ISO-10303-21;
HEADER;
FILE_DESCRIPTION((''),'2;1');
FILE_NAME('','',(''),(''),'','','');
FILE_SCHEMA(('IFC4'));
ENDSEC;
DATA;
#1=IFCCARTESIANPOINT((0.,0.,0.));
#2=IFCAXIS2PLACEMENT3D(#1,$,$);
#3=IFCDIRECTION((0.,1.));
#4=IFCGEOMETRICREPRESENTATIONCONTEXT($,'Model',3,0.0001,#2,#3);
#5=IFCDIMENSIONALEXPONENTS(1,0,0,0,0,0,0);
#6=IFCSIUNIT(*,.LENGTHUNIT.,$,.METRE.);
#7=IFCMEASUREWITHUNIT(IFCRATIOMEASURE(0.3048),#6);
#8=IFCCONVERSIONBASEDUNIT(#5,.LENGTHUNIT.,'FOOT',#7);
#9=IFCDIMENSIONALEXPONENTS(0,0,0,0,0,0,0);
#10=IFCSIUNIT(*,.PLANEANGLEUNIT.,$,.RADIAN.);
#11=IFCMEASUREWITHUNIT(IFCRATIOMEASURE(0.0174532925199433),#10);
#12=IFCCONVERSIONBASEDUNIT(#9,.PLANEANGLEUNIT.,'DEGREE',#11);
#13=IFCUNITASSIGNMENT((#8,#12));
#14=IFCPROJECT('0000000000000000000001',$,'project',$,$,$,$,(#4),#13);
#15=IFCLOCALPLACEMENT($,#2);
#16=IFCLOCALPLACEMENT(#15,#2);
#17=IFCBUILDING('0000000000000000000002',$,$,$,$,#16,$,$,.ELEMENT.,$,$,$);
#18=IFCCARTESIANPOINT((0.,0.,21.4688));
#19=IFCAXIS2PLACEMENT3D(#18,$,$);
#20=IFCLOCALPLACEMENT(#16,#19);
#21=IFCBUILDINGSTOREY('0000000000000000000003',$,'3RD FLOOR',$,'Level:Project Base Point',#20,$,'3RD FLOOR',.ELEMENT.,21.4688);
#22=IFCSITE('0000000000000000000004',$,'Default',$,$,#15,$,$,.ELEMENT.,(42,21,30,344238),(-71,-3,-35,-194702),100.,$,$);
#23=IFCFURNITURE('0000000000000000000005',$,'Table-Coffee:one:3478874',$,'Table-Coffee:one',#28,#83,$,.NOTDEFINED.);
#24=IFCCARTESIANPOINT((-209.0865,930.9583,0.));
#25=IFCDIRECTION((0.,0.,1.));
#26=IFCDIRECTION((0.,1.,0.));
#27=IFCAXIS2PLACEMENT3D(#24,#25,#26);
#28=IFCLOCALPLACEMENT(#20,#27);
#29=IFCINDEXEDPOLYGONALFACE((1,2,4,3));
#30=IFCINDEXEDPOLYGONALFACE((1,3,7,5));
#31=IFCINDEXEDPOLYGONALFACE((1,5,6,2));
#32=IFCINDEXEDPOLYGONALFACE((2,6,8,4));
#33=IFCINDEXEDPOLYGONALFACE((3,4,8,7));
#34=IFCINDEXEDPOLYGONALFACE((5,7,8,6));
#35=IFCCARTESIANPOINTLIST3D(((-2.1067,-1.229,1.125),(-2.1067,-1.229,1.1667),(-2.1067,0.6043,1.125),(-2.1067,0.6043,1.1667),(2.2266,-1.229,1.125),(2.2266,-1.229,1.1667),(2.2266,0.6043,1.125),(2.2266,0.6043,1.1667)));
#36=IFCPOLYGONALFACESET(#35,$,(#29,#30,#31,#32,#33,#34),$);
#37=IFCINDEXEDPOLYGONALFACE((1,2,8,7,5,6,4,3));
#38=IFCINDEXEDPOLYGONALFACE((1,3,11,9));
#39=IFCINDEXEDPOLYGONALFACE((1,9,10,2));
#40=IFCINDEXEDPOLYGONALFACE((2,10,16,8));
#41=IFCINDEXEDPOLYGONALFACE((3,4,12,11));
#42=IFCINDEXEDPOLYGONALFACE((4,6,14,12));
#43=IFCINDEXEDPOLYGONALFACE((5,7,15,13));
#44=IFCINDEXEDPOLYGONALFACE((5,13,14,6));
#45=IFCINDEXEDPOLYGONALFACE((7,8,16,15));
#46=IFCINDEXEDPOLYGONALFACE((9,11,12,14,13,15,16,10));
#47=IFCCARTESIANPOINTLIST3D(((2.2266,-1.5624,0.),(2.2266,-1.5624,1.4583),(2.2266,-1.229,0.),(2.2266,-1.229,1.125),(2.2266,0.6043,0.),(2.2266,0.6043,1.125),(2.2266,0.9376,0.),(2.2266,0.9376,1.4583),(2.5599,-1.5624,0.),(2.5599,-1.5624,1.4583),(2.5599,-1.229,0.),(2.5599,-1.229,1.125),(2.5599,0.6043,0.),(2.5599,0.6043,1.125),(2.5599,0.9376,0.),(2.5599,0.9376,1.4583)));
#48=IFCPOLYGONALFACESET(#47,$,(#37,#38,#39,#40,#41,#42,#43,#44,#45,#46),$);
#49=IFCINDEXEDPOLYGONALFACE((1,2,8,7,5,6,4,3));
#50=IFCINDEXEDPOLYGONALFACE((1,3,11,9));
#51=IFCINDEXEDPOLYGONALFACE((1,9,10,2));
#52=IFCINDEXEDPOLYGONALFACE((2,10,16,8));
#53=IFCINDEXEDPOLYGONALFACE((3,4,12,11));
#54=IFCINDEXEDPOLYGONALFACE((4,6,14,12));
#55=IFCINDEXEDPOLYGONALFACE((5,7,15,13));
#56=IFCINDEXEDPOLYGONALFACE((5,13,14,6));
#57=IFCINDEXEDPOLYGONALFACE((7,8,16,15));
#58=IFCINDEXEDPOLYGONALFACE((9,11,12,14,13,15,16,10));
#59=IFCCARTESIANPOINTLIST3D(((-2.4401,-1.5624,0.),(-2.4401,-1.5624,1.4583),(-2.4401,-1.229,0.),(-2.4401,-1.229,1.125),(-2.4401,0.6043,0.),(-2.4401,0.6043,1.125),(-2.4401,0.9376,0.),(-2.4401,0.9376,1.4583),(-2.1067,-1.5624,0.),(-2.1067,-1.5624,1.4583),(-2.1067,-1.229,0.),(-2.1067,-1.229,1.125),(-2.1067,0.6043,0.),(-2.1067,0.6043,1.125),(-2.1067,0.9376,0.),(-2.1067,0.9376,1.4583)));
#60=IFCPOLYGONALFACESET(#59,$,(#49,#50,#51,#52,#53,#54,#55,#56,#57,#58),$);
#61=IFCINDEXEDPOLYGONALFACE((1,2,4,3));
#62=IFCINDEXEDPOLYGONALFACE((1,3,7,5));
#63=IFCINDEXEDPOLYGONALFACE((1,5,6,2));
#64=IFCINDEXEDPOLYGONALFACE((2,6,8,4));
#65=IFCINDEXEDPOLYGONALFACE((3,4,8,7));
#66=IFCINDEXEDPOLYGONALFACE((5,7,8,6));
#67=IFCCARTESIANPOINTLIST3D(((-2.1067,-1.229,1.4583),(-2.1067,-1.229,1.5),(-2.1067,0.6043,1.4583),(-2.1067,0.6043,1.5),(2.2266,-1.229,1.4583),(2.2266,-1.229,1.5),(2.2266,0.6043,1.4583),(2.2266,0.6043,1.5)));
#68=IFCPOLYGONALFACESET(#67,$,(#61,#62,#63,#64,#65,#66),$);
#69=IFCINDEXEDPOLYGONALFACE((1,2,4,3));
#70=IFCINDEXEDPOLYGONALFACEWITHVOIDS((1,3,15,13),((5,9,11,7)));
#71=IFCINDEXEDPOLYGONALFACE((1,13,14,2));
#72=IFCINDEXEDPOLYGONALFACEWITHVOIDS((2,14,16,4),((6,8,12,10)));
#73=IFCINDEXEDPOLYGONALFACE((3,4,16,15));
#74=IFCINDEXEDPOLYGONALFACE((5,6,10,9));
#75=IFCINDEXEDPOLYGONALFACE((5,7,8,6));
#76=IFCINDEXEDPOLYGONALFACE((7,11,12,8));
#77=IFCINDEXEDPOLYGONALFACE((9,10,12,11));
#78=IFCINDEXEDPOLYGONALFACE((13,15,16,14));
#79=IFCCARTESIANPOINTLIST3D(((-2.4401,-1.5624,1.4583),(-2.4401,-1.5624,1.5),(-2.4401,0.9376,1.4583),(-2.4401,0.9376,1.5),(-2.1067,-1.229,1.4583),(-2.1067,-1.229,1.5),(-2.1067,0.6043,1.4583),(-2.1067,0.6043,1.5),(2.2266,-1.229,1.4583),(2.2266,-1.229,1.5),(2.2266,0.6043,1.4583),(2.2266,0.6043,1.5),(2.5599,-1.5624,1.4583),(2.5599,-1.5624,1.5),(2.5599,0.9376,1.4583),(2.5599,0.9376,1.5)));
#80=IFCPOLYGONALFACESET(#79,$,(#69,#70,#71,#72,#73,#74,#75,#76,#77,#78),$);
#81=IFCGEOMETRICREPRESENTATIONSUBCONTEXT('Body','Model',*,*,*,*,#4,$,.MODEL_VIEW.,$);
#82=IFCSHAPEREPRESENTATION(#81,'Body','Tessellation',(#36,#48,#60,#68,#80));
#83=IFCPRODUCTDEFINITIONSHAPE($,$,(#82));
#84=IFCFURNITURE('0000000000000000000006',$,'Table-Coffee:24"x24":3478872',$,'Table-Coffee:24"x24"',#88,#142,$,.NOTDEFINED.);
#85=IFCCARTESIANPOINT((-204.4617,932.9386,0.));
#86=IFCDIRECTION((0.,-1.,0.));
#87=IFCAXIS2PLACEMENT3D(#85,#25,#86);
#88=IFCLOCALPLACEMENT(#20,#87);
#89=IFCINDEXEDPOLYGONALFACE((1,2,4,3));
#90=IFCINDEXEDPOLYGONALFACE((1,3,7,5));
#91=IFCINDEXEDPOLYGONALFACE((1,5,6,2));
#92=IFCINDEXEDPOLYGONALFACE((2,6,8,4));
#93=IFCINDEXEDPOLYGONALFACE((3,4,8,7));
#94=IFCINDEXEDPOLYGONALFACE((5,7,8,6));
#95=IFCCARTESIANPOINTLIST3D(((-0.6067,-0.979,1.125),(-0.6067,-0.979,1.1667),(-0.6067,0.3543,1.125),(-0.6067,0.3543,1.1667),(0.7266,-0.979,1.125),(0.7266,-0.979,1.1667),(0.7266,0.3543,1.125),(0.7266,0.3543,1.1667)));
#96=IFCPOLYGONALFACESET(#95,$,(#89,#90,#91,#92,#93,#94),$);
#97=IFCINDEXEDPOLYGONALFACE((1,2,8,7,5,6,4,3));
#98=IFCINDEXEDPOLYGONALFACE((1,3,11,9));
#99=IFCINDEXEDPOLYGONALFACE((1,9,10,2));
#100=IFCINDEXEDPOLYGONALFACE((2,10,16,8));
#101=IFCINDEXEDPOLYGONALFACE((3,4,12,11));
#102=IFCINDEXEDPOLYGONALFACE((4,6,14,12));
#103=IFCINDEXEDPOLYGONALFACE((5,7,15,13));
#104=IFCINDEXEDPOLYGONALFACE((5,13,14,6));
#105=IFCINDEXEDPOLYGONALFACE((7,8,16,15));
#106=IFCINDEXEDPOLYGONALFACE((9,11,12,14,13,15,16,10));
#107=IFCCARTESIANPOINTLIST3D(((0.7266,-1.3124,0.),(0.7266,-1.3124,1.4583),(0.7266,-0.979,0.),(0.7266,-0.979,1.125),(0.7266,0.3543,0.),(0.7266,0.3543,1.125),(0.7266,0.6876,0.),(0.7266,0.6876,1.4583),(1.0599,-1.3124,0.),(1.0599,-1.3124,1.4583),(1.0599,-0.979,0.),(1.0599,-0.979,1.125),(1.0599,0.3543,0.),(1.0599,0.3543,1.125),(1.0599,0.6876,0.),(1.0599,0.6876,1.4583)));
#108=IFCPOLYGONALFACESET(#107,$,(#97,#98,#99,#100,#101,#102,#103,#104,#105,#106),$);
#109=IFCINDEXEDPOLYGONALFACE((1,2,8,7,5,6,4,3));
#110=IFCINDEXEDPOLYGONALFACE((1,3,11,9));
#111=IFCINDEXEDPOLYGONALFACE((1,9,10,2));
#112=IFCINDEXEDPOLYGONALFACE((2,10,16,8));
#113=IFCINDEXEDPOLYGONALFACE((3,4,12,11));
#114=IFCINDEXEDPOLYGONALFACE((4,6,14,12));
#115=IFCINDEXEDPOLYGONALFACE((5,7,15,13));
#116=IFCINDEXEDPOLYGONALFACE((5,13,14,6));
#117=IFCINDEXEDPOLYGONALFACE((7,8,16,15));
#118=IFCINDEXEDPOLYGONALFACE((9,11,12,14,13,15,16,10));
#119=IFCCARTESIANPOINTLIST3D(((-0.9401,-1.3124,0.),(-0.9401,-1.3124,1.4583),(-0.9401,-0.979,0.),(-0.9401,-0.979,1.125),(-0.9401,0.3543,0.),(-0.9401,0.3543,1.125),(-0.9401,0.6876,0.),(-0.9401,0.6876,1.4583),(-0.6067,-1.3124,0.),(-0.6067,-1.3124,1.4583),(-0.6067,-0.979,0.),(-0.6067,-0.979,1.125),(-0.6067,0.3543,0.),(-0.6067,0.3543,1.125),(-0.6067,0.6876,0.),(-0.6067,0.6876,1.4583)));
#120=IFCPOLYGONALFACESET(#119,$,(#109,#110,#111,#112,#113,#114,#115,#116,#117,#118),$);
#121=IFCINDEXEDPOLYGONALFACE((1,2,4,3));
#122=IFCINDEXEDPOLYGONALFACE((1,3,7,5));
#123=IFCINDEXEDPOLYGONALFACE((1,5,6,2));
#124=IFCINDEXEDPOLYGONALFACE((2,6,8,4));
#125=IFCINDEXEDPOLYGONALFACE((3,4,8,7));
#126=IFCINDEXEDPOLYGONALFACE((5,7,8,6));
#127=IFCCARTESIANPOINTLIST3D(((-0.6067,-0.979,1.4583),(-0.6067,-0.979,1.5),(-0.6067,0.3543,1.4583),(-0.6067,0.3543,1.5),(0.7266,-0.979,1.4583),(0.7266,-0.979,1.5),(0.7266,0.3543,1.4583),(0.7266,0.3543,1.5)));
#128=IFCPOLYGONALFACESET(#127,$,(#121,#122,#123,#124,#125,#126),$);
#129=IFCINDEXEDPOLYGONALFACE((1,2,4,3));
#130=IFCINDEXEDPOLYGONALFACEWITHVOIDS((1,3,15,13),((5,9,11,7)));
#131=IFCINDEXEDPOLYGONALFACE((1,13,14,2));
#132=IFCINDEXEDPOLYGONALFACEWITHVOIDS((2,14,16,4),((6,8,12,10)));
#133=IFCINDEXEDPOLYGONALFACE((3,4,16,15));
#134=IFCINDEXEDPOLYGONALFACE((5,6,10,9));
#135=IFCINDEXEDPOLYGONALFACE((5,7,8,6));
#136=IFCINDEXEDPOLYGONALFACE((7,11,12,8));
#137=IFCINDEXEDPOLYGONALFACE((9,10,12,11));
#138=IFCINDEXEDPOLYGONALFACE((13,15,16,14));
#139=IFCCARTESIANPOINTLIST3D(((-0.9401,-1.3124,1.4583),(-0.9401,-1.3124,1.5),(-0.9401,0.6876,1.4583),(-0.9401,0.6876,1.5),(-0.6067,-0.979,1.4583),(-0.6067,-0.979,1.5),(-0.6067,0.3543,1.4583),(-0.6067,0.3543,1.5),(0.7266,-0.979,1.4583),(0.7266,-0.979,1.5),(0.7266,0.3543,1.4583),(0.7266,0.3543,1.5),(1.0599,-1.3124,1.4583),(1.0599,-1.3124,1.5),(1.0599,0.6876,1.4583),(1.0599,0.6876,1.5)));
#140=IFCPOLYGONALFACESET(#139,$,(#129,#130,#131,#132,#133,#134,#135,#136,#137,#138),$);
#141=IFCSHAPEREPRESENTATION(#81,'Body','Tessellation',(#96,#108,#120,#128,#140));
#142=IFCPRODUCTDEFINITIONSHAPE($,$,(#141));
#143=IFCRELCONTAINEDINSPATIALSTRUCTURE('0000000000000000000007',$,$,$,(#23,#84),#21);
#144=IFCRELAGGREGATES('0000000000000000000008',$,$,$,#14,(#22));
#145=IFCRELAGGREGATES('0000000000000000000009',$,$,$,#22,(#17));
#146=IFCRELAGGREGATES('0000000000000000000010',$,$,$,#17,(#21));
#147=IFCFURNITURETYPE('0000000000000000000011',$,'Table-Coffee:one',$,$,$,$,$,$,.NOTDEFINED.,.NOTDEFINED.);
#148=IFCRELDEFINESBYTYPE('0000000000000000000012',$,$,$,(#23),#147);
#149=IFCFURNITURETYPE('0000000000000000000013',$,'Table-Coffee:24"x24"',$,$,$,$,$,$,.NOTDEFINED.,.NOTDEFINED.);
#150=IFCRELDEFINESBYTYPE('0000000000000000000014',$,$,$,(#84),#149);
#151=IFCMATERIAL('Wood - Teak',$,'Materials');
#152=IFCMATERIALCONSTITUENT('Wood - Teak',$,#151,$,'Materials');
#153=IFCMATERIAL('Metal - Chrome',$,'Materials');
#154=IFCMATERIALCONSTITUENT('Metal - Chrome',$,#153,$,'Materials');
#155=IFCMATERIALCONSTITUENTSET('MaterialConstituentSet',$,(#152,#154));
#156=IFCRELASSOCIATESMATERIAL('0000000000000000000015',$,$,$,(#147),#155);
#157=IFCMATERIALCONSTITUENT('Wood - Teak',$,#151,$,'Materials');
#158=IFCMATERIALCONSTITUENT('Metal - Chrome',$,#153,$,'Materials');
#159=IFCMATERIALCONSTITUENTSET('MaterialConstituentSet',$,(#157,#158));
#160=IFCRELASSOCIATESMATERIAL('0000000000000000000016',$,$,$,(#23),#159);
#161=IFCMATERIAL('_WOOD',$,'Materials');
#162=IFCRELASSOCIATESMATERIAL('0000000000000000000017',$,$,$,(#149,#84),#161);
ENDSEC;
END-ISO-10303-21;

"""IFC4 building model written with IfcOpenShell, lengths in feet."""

from ifc_helpers import new_model, entity, si_unit, converted_unit, direction, frame, origin, origin_2d_with_axis, place, context, subcontext, project, spatial, polyline, rectangle, outline, extrude, source, transform, mapped, material, constituent, constituent_set, type_object, type_shapes, element, save


model = new_model("IFC4")

# Units and contexts
model_context = context("Model", 3, precision=0.0001, world=origin(), true_north=direction((0.0, 1.0)))
body_context = subcontext(model_context, "Body", "Model", "MODEL_VIEW")
ifc_project = project(units=[converted_unit("LENGTHUNIT", "FOOT", entity("IfcRatioMeasure", 0.3048), si_unit("LENGTHUNIT", "METRE"), dimensions=[1, 0, 0, 0, 0, 0, 0]), converted_unit("PLANEANGLEUNIT", "DEGREE", entity("IfcRatioMeasure", 0.0174532925199433), si_unit("PLANEANGLEUNIT", "RADIAN"), dimensions=[0, 0, 0, 0, 0, 0, 0])], contexts=[model_context])

# Site, building, storey
site_placement = place(None, origin())
site = spatial("IfcSite", under=ifc_project, at=site_placement, Name="Default", CompositionType="ELEMENT", RefLatitude=(42, 21, 30, 344238), RefLongitude=(-71, -3, -35, -194702), RefElevation=100.0)
building_placement = place(site_placement, origin())
building = spatial("IfcBuilding", under=site, at=building_placement, CompositionType="ELEMENT")
storey_placement = place(building_placement, frame((0.0, 0.0, 21.4688)))
storey = spatial("IfcBuildingStorey", under=building, at=storey_placement, Name="3RD FLOOR", ObjectType="Level:Project Base Point", LongName="3RD FLOOR", CompositionType="ELEMENT", Elevation=21.4688)

# Furniture
ifc_material_1 = material(Name="Wood - Teak", Category="Materials")
ifc_constituent_1 = constituent(ifc_material_1, Name="Wood - Teak", Category="Materials")
ifc_material_2 = material(Name="Metal - Chrome", Category="Materials")
ifc_constituent_2 = constituent(ifc_material_2, Name="Metal - Chrome", Category="Materials")
ifc_constituent_set_1 = constituent_set(constituents=[ifc_constituent_1, ifc_constituent_2], Name="MaterialConstituentSet")
ifc_constituent_3 = constituent(ifc_material_1, Name="Wood - Teak", Category="Materials")
ifc_constituent_4 = constituent(ifc_material_2, Name="Metal - Chrome", Category="Materials")
ifc_constituent_set_2 = constituent_set(constituents=[ifc_constituent_3, ifc_constituent_4], Name="MaterialConstituentSet")
furniture_type_1 = type_object("IfcFurnitureType", Name="Table-Coffee:one", AssemblyPlace="NOTDEFINED", PredefinedType="NOTDEFINED", material=ifc_constituent_set_2)
shared_shape_1 = source(origin(), body_context, "Body", "SweptSolid", [
    extrude(rectangle(XDim=1.8333, YDim=4.3333, at=origin_2d_with_axis()), frame((0.0599, -0.3124, 1.125), z_axis=(0.0, 0.0, 1.0), x_axis=(0.0, 1.0, 0.0)), (0.0, 0.0, 1.0), 0.0417),
    extrude(outline(polyline([(-1.25, -0.6458), (-0.9167, -0.6458), (-0.9167, 0.4792), (0.9167, 0.4792), (0.9167, -0.6458), (1.25, -0.6458), (1.25, 0.8125), (-1.25, 0.8125), (-1.25, -0.6458)])), frame((2.2266, -0.3124, 0.6458), z_axis=(1.0, 0.0, 0.0), x_axis=(0.0, 1.0, 0.0)), (0.0, 0.0, 1.0), 0.3333),
    extrude(outline(polyline([(-0.8125, -1.25), (0.6458, -1.25), (0.6458, -0.9167), (-0.4792, -0.9167), (-0.4792, 0.9167), (0.6458, 0.9167), (0.6458, 1.25), (-0.8125, 1.25), (-0.8125, -1.25)])), frame((-2.4401, -0.3124, 0.6458), z_axis=(1.0, 0.0, 0.0), x_axis=(0.0, 0.0, -1.0)), (0.0, 0.0, 1.0), 0.3333),
    extrude(rectangle(XDim=1.8333, YDim=4.3333, at=origin_2d_with_axis()), frame((0.0599, -0.3124, 1.4583), z_axis=(0.0, 0.0, 1.0), x_axis=(0.0, 1.0, 0.0)), (0.0, 0.0, 1.0), 0.0417),
    extrude(outline(polyline([(-1.25, -2.5), (1.25, -2.5), (1.25, 2.5), (-1.25, 2.5), (-1.25, -2.5)]), holes=[polyline([(-0.9167, -2.1667), (-0.9167, 2.1667), (0.9167, 2.1667), (0.9167, -2.1667), (-0.9167, -2.1667)])]), frame((0.0599, -0.3124, 1.4583), z_axis=(0.0, 0.0, 1.0), x_axis=(0.0, 1.0, 0.0)), (0.0, 0.0, 1.0), 0.0417),
])
type_shapes(furniture_type_1, [shared_shape_1])
furniture_1_placement = place(storey_placement, frame((-209.0865, 930.9583, 0.0), z_axis=(0.0, 0.0, 1.0), x_axis=(0.0, 1.0, 0.0)))
element("IfcFurniture", 1, at=furniture_1_placement, inside=storey, type_object=furniture_type_1, material=ifc_constituent_set_1, Name="Table-Coffee:one:3478874", ObjectType="Table-Coffee:one", PredefinedType="NOTDEFINED", context=body_context, shape_type="MappedRepresentation", body=[
    mapped(shared_shape_1, transform((0.0, 0.0, 0.0), scale=1.0)),
])
ifc_material_3 = material(Name="_WOOD", Category="Materials")
furniture_type_2 = type_object("IfcFurnitureType", Name="Table-Coffee:24\"x24\"", AssemblyPlace="NOTDEFINED", PredefinedType="NOTDEFINED", material=ifc_material_3)
shared_shape_2 = source(origin(), body_context, "Body", "SweptSolid", [
    extrude(rectangle(XDim=1.3333, YDim=1.3333, at=origin_2d_with_axis()), frame((0.0599, -0.3124, 1.125), z_axis=(0.0, 0.0, 1.0), x_axis=(0.0, 1.0, 0.0)), (0.0, 0.0, 1.0), 0.0417),
    extrude(outline(polyline([(-1.0, -0.6458), (-0.6667, -0.6458), (-0.6667, 0.4792), (0.6667, 0.4792), (0.6667, -0.6458), (1.0, -0.6458), (1.0, 0.8125), (-1.0, 0.8125), (-1.0, -0.6458)])), frame((0.7266, -0.3124, 0.6458), z_axis=(1.0, 0.0, 0.0), x_axis=(0.0, 1.0, 0.0)), (0.0, 0.0, 1.0), 0.3333),
    extrude(outline(polyline([(-0.8125, -1.0), (0.6458, -1.0), (0.6458, -0.6667), (-0.4792, -0.6667), (-0.4792, 0.6667), (0.6458, 0.6667), (0.6458, 1.0), (-0.8125, 1.0), (-0.8125, -1.0)])), frame((-0.9401, -0.3124, 0.6458), z_axis=(1.0, 0.0, 0.0), x_axis=(0.0, 0.0, -1.0)), (0.0, 0.0, 1.0), 0.3333),
    extrude(rectangle(XDim=1.3333, YDim=1.3333, at=origin_2d_with_axis()), frame((0.0599, -0.3124, 1.4583), z_axis=(0.0, 0.0, 1.0), x_axis=(0.0, 1.0, 0.0)), (0.0, 0.0, 1.0), 0.0417),
    extrude(outline(polyline([(-1.0, -1.0), (1.0, -1.0), (1.0, 1.0), (-1.0, 1.0), (-1.0, -1.0)]), holes=[polyline([(-0.6667, -0.6667), (-0.6667, 0.6667), (0.6667, 0.6667), (0.6667, -0.6667), (-0.6667, -0.6667)])]), frame((0.0599, -0.3124, 1.4583), z_axis=(0.0, 0.0, 1.0), x_axis=(0.0, 1.0, 0.0)), (0.0, 0.0, 1.0), 0.0417),
])
type_shapes(furniture_type_2, [shared_shape_2])
furniture_2_placement = place(storey_placement, frame((-204.4617, 932.9386, 0.0), z_axis=(0.0, 0.0, 1.0), x_axis=(0.0, -1.0, 0.0)))
element("IfcFurniture", 2, at=furniture_2_placement, inside=storey, type_object=furniture_type_2, material=ifc_material_3, Name="Table-Coffee:24\"x24\":3478872", ObjectType="Table-Coffee:24\"x24\"", PredefinedType="NOTDEFINED", context=body_context, shape_type="MappedRepresentation", body=[
    mapped(shared_shape_2, transform((0.0, 0.0, 0.0), scale=1.0)),
])

save(model, "model.ifc")
